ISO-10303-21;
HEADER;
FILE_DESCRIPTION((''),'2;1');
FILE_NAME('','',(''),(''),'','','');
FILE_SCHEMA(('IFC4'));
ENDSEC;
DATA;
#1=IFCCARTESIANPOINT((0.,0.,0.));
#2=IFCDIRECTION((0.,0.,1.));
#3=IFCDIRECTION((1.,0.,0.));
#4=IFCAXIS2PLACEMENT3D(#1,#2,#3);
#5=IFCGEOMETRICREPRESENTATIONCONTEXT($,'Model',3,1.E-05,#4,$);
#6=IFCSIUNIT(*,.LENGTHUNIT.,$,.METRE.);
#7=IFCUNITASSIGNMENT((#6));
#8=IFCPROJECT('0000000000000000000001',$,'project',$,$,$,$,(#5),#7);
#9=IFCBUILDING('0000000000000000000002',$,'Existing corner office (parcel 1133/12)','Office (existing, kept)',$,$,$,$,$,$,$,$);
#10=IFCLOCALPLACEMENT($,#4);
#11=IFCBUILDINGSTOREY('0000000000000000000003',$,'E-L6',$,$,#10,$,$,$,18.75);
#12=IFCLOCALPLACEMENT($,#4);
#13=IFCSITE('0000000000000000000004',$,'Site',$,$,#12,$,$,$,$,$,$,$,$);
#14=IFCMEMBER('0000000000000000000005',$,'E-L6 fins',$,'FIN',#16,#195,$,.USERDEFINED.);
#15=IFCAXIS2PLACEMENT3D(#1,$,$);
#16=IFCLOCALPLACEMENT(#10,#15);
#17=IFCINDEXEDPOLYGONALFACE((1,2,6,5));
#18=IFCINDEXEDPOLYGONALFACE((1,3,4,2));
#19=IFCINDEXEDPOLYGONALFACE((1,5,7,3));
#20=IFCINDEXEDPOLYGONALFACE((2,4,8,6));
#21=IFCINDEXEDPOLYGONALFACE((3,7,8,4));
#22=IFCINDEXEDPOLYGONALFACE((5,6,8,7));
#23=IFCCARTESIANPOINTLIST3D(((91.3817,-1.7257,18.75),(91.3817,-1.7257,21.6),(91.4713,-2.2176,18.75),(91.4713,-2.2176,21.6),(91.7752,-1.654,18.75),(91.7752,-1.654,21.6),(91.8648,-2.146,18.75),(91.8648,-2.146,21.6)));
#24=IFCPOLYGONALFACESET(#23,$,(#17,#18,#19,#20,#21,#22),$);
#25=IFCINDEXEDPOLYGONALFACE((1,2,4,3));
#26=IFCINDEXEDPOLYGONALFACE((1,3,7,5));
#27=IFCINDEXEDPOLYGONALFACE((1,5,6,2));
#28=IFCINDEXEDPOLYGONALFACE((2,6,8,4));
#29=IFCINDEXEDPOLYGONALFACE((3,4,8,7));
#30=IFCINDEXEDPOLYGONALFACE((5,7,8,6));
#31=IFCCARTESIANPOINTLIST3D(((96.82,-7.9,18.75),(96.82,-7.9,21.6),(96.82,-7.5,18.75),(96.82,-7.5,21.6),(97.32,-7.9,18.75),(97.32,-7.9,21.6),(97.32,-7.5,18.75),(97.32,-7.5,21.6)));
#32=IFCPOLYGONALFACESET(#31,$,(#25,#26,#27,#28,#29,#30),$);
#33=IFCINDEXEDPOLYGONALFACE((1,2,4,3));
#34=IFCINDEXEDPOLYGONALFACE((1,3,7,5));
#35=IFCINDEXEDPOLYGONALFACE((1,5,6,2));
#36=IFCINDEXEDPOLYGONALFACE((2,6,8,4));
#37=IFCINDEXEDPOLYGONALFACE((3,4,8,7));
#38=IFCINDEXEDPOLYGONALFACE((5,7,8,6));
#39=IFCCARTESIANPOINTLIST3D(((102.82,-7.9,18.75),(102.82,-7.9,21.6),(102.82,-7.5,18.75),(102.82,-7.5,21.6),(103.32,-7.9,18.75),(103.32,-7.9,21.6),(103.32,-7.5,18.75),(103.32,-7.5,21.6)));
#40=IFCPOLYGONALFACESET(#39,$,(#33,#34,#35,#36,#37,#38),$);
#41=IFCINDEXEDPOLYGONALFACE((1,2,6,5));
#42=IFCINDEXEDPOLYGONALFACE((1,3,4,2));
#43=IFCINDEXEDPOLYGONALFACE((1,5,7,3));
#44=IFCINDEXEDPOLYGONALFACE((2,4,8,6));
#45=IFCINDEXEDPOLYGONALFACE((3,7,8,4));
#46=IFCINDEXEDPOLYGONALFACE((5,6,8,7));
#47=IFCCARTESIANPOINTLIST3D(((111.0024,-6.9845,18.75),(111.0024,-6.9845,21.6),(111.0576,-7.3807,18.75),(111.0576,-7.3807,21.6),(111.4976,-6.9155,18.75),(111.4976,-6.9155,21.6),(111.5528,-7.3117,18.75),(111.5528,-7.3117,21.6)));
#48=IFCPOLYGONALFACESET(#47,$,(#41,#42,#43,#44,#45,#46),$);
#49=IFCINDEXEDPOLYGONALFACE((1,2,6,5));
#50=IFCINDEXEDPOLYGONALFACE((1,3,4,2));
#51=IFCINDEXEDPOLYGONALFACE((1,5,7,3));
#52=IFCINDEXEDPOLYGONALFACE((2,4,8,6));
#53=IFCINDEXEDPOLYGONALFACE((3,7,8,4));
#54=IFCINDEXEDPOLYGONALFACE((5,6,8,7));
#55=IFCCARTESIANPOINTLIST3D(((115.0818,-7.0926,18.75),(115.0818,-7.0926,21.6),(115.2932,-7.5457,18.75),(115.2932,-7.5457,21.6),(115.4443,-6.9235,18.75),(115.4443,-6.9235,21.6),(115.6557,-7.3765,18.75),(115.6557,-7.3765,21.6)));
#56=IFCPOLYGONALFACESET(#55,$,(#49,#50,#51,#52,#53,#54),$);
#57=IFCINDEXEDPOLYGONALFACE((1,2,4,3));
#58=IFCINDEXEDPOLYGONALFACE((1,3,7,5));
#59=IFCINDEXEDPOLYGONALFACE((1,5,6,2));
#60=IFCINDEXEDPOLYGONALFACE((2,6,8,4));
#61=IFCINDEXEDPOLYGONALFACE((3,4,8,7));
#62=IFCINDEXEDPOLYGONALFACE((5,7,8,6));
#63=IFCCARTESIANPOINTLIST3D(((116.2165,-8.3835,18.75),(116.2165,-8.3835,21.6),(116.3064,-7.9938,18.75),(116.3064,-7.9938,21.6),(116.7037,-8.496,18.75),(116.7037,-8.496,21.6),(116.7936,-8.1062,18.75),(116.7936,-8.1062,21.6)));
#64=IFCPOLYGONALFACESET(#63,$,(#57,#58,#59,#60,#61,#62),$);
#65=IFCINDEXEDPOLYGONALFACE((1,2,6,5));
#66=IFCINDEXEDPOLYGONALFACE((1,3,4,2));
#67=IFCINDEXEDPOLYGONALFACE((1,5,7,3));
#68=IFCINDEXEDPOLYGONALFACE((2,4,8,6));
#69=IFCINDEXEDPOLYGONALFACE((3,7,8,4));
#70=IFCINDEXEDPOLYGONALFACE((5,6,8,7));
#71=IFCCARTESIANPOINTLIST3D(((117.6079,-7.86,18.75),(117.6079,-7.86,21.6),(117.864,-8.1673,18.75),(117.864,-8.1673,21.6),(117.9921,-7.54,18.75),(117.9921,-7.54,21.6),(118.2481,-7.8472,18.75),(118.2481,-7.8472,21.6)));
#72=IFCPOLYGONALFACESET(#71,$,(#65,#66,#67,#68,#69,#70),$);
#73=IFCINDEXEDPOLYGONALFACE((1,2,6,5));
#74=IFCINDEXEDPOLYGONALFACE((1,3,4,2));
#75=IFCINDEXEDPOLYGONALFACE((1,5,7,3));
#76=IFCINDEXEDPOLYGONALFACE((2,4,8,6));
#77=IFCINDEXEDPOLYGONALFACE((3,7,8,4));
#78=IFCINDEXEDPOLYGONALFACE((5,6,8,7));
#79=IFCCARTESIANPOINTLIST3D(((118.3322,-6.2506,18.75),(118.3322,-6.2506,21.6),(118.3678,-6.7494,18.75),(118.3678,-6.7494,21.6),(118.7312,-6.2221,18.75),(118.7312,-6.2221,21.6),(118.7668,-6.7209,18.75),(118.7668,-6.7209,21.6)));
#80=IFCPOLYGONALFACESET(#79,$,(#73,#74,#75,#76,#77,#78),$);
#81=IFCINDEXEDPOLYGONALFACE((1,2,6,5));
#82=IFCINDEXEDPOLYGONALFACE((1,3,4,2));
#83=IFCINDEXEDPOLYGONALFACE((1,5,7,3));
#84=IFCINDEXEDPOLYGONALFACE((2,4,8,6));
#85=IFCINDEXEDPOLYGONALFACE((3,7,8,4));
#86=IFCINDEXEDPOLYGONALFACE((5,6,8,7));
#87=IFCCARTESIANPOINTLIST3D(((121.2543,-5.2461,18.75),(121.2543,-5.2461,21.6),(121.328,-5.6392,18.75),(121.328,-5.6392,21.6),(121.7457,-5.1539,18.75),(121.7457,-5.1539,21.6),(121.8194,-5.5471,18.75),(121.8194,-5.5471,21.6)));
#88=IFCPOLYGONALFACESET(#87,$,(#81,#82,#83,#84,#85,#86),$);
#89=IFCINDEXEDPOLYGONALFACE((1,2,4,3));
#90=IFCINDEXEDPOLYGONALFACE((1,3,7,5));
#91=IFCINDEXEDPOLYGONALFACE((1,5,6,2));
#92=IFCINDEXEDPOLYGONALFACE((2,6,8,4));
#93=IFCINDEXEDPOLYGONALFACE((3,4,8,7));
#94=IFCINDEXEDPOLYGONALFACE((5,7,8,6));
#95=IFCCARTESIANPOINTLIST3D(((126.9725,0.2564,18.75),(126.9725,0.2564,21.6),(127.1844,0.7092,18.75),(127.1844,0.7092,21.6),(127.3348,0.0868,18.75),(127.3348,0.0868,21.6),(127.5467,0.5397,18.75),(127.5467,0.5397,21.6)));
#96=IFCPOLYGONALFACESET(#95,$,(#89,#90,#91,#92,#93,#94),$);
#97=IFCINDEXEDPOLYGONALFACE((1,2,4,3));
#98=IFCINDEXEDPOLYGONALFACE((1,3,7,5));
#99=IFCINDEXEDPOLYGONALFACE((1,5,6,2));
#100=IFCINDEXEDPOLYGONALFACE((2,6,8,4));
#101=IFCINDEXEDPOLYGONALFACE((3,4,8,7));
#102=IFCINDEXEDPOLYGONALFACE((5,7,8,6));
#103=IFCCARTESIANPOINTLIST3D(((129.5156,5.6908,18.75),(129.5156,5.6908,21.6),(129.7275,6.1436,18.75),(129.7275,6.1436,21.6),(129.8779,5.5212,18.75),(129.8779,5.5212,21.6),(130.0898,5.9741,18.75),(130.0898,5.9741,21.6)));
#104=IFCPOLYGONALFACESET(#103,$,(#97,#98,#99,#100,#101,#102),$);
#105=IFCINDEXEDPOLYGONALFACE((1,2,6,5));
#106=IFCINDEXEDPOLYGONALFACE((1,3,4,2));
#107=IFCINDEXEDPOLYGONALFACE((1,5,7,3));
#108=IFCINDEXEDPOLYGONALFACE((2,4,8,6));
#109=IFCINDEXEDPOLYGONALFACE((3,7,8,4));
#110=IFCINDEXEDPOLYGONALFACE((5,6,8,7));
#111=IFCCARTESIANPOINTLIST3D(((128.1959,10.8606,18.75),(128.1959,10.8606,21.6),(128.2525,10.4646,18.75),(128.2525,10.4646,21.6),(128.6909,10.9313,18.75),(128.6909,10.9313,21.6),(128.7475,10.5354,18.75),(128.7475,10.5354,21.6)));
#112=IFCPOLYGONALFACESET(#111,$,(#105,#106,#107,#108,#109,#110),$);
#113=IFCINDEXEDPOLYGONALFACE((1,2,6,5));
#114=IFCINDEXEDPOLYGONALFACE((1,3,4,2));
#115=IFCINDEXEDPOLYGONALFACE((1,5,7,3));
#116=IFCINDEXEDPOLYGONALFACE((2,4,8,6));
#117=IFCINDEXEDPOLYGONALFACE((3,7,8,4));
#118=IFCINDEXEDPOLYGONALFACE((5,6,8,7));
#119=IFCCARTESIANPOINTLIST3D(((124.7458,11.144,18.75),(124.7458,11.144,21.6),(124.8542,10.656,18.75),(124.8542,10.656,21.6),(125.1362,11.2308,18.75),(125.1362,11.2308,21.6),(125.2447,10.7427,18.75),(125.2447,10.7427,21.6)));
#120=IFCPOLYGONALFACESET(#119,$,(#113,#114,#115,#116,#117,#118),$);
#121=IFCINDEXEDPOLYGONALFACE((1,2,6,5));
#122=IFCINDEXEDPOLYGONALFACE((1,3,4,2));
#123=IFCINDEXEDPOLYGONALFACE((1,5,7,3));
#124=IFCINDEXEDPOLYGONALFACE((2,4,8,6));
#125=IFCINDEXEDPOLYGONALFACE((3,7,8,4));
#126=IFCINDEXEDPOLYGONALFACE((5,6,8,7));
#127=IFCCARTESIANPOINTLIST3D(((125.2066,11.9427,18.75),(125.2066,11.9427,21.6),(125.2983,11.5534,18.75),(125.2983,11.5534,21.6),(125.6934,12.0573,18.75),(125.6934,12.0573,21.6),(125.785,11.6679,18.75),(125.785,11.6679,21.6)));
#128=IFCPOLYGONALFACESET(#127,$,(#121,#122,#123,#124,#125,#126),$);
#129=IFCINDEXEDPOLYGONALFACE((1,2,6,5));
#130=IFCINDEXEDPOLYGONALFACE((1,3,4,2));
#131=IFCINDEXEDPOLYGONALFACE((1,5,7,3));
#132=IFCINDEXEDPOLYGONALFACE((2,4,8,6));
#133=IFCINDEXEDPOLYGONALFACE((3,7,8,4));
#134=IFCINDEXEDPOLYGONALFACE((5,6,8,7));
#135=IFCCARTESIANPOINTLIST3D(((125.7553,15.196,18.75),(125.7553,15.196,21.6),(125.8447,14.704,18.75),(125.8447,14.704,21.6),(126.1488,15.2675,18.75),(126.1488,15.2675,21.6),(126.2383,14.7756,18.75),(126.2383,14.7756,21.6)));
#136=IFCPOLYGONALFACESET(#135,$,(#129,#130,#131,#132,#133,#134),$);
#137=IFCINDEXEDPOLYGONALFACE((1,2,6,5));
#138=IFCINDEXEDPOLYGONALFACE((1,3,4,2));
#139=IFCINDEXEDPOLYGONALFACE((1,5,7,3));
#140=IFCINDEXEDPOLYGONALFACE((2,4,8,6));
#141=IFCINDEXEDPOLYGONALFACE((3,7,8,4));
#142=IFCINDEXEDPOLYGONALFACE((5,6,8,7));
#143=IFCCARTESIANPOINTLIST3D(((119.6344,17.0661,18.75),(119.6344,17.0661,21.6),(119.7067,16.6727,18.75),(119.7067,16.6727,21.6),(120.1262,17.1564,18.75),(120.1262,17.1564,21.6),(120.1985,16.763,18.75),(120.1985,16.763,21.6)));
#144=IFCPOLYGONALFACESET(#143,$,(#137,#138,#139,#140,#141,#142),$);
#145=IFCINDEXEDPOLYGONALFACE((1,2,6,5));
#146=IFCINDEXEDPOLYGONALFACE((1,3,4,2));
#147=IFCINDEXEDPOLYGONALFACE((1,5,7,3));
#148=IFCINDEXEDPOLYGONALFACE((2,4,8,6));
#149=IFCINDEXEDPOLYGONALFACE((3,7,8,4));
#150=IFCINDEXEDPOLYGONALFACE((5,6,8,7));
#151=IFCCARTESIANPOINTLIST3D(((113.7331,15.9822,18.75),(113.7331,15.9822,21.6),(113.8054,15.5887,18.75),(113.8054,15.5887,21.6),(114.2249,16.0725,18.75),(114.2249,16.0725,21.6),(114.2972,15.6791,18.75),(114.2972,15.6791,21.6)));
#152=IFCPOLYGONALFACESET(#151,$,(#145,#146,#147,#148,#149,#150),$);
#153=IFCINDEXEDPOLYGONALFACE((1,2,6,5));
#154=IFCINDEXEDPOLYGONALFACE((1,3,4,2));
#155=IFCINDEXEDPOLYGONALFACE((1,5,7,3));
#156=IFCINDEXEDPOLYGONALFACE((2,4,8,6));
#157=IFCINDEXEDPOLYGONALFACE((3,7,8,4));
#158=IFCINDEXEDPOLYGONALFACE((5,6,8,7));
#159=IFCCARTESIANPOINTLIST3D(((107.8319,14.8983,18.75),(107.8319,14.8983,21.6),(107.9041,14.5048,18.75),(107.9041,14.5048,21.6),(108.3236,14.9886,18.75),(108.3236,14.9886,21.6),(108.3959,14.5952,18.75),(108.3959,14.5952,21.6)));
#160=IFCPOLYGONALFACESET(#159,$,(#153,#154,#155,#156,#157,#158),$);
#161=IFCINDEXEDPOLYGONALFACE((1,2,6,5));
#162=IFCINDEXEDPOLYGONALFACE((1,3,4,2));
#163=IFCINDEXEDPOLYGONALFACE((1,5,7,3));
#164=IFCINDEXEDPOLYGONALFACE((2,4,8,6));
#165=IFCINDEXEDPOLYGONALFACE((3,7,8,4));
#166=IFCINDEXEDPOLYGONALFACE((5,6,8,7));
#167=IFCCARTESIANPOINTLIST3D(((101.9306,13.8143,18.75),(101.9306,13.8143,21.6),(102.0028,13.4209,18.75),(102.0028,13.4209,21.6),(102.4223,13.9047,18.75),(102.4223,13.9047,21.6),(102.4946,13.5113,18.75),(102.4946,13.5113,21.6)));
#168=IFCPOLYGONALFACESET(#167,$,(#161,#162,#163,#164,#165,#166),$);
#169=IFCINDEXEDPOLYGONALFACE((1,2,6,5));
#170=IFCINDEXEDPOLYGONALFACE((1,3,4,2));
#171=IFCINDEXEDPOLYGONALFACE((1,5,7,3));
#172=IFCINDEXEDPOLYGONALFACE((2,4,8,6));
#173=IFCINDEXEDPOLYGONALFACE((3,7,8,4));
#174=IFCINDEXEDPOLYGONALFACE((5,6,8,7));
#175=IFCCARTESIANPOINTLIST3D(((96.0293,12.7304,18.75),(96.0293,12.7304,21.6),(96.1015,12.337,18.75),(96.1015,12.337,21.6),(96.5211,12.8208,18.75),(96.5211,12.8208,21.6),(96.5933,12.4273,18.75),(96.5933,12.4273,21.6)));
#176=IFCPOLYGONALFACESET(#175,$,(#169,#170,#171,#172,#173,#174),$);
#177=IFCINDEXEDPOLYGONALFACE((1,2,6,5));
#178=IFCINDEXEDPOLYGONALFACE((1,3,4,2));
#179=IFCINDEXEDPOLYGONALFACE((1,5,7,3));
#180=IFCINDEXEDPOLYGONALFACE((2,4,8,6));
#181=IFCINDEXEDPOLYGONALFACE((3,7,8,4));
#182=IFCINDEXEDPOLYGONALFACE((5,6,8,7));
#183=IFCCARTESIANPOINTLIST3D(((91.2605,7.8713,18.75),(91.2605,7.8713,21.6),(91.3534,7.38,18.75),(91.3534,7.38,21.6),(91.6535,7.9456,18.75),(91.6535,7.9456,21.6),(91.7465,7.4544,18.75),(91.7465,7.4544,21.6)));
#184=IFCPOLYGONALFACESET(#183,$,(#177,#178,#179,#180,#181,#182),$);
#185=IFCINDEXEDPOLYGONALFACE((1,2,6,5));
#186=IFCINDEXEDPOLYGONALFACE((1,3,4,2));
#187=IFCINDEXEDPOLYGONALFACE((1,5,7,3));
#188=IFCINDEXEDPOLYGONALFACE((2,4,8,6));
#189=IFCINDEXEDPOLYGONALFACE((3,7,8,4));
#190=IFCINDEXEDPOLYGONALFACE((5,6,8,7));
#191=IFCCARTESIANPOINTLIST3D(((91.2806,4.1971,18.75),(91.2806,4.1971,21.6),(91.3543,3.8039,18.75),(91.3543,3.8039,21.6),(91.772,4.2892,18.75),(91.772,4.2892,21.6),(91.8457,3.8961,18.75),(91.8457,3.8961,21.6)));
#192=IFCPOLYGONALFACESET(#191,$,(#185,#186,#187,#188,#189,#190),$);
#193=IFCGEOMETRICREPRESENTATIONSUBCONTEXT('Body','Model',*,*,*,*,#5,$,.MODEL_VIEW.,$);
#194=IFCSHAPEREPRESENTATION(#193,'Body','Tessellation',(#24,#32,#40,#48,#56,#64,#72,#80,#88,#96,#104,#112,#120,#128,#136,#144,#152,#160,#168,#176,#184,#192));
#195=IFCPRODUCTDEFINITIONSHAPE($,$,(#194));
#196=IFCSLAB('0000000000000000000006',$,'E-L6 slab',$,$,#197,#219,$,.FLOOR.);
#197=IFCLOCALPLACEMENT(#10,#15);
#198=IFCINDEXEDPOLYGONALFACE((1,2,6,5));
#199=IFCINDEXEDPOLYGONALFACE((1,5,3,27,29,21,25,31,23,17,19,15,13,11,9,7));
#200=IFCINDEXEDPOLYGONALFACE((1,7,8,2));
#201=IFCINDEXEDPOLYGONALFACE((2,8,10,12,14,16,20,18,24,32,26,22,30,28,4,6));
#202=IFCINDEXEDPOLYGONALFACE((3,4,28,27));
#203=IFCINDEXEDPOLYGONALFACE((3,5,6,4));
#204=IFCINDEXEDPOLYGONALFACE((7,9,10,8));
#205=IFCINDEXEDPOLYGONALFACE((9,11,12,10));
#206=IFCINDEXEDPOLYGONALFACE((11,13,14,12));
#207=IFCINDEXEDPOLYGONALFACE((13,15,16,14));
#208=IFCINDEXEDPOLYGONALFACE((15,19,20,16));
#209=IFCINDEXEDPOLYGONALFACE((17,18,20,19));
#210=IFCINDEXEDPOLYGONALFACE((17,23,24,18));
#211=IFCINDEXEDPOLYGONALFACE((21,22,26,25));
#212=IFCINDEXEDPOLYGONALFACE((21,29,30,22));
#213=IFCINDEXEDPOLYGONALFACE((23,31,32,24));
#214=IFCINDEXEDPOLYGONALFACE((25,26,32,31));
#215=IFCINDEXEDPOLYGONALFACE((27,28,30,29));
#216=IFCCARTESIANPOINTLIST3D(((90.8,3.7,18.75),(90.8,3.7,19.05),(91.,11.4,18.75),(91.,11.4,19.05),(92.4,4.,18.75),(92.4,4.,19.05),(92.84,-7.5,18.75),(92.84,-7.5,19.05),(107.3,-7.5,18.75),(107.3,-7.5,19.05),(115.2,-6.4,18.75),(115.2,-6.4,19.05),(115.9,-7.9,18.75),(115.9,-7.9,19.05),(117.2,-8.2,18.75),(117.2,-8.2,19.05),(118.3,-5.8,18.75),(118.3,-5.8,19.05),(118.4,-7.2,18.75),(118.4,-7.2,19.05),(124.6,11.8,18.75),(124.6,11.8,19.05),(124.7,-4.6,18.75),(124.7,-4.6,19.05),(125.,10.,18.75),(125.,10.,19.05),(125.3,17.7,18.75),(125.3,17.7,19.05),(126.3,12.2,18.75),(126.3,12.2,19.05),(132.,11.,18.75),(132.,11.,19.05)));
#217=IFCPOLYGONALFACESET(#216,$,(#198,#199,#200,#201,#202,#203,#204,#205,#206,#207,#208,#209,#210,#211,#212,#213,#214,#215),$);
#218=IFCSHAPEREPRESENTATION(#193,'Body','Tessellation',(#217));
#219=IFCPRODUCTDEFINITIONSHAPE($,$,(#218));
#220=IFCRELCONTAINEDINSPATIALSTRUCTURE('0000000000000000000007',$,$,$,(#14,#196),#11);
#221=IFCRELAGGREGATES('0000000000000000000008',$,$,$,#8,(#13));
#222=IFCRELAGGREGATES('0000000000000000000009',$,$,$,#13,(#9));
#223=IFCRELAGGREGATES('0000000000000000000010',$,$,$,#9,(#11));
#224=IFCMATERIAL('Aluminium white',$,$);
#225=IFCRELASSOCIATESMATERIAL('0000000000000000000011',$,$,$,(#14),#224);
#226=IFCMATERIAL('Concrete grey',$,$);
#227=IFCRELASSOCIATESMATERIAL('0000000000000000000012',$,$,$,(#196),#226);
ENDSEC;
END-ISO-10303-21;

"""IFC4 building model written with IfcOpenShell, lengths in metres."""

from ifc_helpers import new_model, si_unit, frame, origin_with_axes, place, context, subcontext, project, spatial, polyline, outline, extrude, material, element, save


model = new_model("IFC4")

# Units and contexts
model_context = context("Model", 3, precision=1e-05, world=origin_with_axes())
body_context = subcontext(model_context, "Body", "Model", "MODEL_VIEW")
ifc_project = project(units=[si_unit("LENGTHUNIT", "METRE")], contexts=[model_context])

# Site, building, storey
site_placement = place(None, origin_with_axes())
site = spatial("IfcSite", under=ifc_project, at=site_placement, Name="Site")
building = spatial("IfcBuilding", under=site, Name="Existing corner office (parcel 1133/12)", Description="Office (existing, kept)")
storey_placement = place(None, origin_with_axes())
storey = spatial("IfcBuildingStorey", under=building, at=storey_placement, Name="E-L6", Elevation=18.75)

# Member
ifc_material_1 = material(Name="Aluminium white")
member_1_placement = place(storey_placement, origin_with_axes())
element("IfcMember", 1, at=member_1_placement, inside=storey, material=ifc_material_1, Name="E-L6 fins", ObjectType="FIN", PredefinedType="USERDEFINED", context=body_context, shape_type="SweptSolid", body=[
    extrude(outline(polyline([(-0.2, -0.25), (0.2, -0.25), (0.2, 0.25), (-0.2, 0.25), (-0.2, -0.25)])), frame((91.6232, -1.9358, 18.75), z_axis=(0.0, 0.0, 1.0), x_axis=(-0.983814, -0.179195, 0.0)), (0.0, 0.0, 1.0), 2.85),
    extrude(outline(polyline([(-0.2, -0.25), (0.2, -0.25), (0.2, 0.25), (-0.2, 0.25), (-0.2, -0.25)])), frame((97.07, -7.7, 18.75), z_axis=(0.0, 0.0, 1.0), x_axis=(0.0, -1.0, 0.0)), (0.0, 0.0, 1.0), 2.85),
    extrude(outline(polyline([(-0.2, -0.25), (0.2, -0.25), (0.2, 0.25), (-0.2, 0.25), (-0.2, -0.25)])), frame((103.07, -7.7, 18.75), z_axis=(0.0, 0.0, 1.0), x_axis=(0.0, -1.0, 0.0)), (0.0, 0.0, 1.0), 2.85),
    extrude(outline(polyline([(-0.2, -0.25), (0.2, -0.25), (0.2, 0.25), (-0.2, 0.25), (-0.2, -0.25)])), frame((111.2776, -7.1481, 18.75), z_axis=(0.0, 0.0, 1.0), x_axis=(0.13791, -0.990445, 0.0)), (0.0, 0.0, 1.0), 2.85),
    extrude(outline(polyline([(-0.2, -0.25), (0.2, -0.25), (0.2, 0.25), (-0.2, 0.25), (-0.2, -0.25)])), frame((115.3688, -7.2346, 18.75), z_axis=(0.0, 0.0, 1.0), x_axis=(-0.906183, -0.422885, 0.0)), (0.0, 0.0, 1.0), 2.85),
    extrude(outline(polyline([(-0.2, -0.25), (0.2, -0.25), (0.2, 0.25), (-0.2, 0.25), (-0.2, -0.25)])), frame((116.505, -8.2449, 18.75), z_axis=(0.0, 0.0, 1.0), x_axis=(-0.22486, -0.974391, 0.0)), (0.0, 0.0, 1.0), 2.85),
    extrude(outline(polyline([(-0.2, -0.25), (0.2, -0.25), (0.2, 0.25), (-0.2, 0.25), (-0.2, -0.25)])), frame((117.928, -7.8536, 18.75), z_axis=(0.0, 0.0, 1.0), x_axis=(0.640184, -0.768221, 0.0)), (0.0, 0.0, 1.0), 2.85),
    extrude(outline(polyline([(-0.2, -0.25), (0.2, -0.25), (0.2, 0.25), (-0.2, 0.25), (-0.2, -0.25)])), frame((118.5495, -6.4858, 18.75), z_axis=(0.0, 0.0, 1.0), x_axis=(0.997459, 0.071247, 0.0)), (0.0, 0.0, 1.0), 2.85),
    extrude(outline(polyline([(-0.2, -0.25), (0.2, -0.25), (0.2, 0.25), (-0.2, 0.25), (-0.2, -0.25)])), frame((121.5369, -5.3966, 18.75), z_axis=(0.0, 0.0, 1.0), x_axis=(0.184289, -0.982872, 0.0)), (0.0, 0.0, 1.0), 2.85),
    extrude(outline(polyline([(-0.2, -0.25), (0.2, -0.25), (0.2, 0.25), (-0.2, 0.25), (-0.2, -0.25)])), frame((127.2596, 0.398, 18.75), z_axis=(0.0, 0.0, 1.0), x_axis=(0.905738, -0.423839, 0.0)), (0.0, 0.0, 1.0), 2.85),
    extrude(outline(polyline([(-0.2, -0.25), (0.2, -0.25), (0.2, 0.25), (-0.2, 0.25), (-0.2, -0.25)])), frame((129.8027, 5.8324, 18.75), z_axis=(0.0, 0.0, 1.0), x_axis=(0.905738, -0.423839, 0.0)), (0.0, 0.0, 1.0), 2.85),
    extrude(outline(polyline([(-0.2, -0.25), (0.2, -0.25), (0.2, 0.25), (-0.2, 0.25), (-0.2, -0.25)])), frame((128.4717, 10.698, 18.75), z_axis=(0.0, 0.0, 1.0), x_axis=(-0.141421, 0.989949, 0.0)), (0.0, 0.0, 1.0), 2.85),
    extrude(outline(polyline([(-0.2, -0.25), (0.2, -0.25), (0.2, 0.25), (-0.2, 0.25), (-0.2, -0.25)])), frame((124.9952, 10.9434, 18.75), z_axis=(0.0, 0.0, 1.0), x_axis=(0.976187, 0.21693, 0.0)), (0.0, 0.0, 1.0), 2.85),
    extrude(outline(polyline([(-0.2, -0.25), (0.2, -0.25), (0.2, 0.25), (-0.2, 0.25), (-0.2, -0.25)])), frame((125.4958, 11.8053, 18.75), z_axis=(0.0, 0.0, 1.0), x_axis=(0.229039, -0.973417, 0.0)), (0.0, 0.0, 1.0), 2.85),
    extrude(outline(polyline([(-0.2, -0.25), (0.2, -0.25), (0.2, 0.25), (-0.2, 0.25), (-0.2, -0.25)])), frame((125.9968, 14.9858, 18.75), z_axis=(0.0, 0.0, 1.0), x_axis=(0.98387, 0.178885, 0.0)), (0.0, 0.0, 1.0), 2.85),
    extrude(outline(polyline([(-0.2, -0.25), (0.2, -0.25), (0.2, 0.25), (-0.2, 0.25), (-0.2, -0.25)])), frame((119.9164, 16.9145, 18.75), z_axis=(0.0, 0.0, 1.0), x_axis=(-0.180652, 0.983547, 0.0)), (0.0, 0.0, 1.0), 2.85),
    extrude(outline(polyline([(-0.2, -0.25), (0.2, -0.25), (0.2, 0.25), (-0.2, 0.25), (-0.2, -0.25)])), frame((114.0152, 15.8306, 18.75), z_axis=(0.0, 0.0, 1.0), x_axis=(-0.180652, 0.983547, 0.0)), (0.0, 0.0, 1.0), 2.85),
    extrude(outline(polyline([(-0.2, -0.25), (0.2, -0.25), (0.2, 0.25), (-0.2, 0.25), (-0.2, -0.25)])), frame((108.1139, 14.7467, 18.75), z_axis=(0.0, 0.0, 1.0), x_axis=(-0.180652, 0.983547, 0.0)), (0.0, 0.0, 1.0), 2.85),
    extrude(outline(polyline([(-0.2, -0.25), (0.2, -0.25), (0.2, 0.25), (-0.2, 0.25), (-0.2, -0.25)])), frame((102.2126, 13.6628, 18.75), z_axis=(0.0, 0.0, 1.0), x_axis=(-0.180652, 0.983547, 0.0)), (0.0, 0.0, 1.0), 2.85),
    extrude(outline(polyline([(-0.2, -0.25), (0.2, -0.25), (0.2, 0.25), (-0.2, 0.25), (-0.2, -0.25)])), frame((96.3113, 12.5789, 18.75), z_axis=(0.0, 0.0, 1.0), x_axis=(-0.180652, 0.983547, 0.0)), (0.0, 0.0, 1.0), 2.85),
    extrude(outline(polyline([(-0.2, -0.25), (0.2, -0.25), (0.2, 0.25), (-0.2, 0.25), (-0.2, -0.25)])), frame((91.5035, 7.6628, 18.75), z_axis=(0.0, 0.0, 1.0), x_axis=(-0.98257, -0.185892, 0.0)), (0.0, 0.0, 1.0), 2.85),
    extrude(outline(polyline([(-0.2, -0.25), (0.2, -0.25), (0.2, 0.25), (-0.2, 0.25), (-0.2, -0.25)])), frame((91.5631, 4.0466, 18.75), z_axis=(0.0, 0.0, 1.0), x_axis=(-0.184289, 0.982872, 0.0)), (0.0, 0.0, 1.0), 2.85),
])

# Slab
ifc_material_2 = material(Name="Concrete grey")
slab_1_placement = place(storey_placement, origin_with_axes())
element("IfcSlab", 2, at=slab_1_placement, inside=storey, material=ifc_material_2, Name="E-L6 slab", PredefinedType="FLOOR", context=body_context, shape_type="SweptSolid", body=[
    extrude(outline(polyline([(90.8, 3.7), (92.84, -7.5), (107.3, -7.5), (115.2, -6.4), (115.9, -7.9), (117.2, -8.2), (118.4, -7.2), (118.3, -5.8), (124.7, -4.6), (132.0, 11.0), (125.0, 10.0), (124.6, 11.8), (126.3, 12.2), (125.3, 17.7), (91.0, 11.4), (92.4, 4.0), (90.8, 3.7)])), frame((0.0, 0.0, 18.75), z_axis=(0.0, 0.0, 1.0), x_axis=(1.0, 0.0, 0.0)), (0.0, 0.0, 1.0), 0.3),
])

save(model, "model.ifc")
